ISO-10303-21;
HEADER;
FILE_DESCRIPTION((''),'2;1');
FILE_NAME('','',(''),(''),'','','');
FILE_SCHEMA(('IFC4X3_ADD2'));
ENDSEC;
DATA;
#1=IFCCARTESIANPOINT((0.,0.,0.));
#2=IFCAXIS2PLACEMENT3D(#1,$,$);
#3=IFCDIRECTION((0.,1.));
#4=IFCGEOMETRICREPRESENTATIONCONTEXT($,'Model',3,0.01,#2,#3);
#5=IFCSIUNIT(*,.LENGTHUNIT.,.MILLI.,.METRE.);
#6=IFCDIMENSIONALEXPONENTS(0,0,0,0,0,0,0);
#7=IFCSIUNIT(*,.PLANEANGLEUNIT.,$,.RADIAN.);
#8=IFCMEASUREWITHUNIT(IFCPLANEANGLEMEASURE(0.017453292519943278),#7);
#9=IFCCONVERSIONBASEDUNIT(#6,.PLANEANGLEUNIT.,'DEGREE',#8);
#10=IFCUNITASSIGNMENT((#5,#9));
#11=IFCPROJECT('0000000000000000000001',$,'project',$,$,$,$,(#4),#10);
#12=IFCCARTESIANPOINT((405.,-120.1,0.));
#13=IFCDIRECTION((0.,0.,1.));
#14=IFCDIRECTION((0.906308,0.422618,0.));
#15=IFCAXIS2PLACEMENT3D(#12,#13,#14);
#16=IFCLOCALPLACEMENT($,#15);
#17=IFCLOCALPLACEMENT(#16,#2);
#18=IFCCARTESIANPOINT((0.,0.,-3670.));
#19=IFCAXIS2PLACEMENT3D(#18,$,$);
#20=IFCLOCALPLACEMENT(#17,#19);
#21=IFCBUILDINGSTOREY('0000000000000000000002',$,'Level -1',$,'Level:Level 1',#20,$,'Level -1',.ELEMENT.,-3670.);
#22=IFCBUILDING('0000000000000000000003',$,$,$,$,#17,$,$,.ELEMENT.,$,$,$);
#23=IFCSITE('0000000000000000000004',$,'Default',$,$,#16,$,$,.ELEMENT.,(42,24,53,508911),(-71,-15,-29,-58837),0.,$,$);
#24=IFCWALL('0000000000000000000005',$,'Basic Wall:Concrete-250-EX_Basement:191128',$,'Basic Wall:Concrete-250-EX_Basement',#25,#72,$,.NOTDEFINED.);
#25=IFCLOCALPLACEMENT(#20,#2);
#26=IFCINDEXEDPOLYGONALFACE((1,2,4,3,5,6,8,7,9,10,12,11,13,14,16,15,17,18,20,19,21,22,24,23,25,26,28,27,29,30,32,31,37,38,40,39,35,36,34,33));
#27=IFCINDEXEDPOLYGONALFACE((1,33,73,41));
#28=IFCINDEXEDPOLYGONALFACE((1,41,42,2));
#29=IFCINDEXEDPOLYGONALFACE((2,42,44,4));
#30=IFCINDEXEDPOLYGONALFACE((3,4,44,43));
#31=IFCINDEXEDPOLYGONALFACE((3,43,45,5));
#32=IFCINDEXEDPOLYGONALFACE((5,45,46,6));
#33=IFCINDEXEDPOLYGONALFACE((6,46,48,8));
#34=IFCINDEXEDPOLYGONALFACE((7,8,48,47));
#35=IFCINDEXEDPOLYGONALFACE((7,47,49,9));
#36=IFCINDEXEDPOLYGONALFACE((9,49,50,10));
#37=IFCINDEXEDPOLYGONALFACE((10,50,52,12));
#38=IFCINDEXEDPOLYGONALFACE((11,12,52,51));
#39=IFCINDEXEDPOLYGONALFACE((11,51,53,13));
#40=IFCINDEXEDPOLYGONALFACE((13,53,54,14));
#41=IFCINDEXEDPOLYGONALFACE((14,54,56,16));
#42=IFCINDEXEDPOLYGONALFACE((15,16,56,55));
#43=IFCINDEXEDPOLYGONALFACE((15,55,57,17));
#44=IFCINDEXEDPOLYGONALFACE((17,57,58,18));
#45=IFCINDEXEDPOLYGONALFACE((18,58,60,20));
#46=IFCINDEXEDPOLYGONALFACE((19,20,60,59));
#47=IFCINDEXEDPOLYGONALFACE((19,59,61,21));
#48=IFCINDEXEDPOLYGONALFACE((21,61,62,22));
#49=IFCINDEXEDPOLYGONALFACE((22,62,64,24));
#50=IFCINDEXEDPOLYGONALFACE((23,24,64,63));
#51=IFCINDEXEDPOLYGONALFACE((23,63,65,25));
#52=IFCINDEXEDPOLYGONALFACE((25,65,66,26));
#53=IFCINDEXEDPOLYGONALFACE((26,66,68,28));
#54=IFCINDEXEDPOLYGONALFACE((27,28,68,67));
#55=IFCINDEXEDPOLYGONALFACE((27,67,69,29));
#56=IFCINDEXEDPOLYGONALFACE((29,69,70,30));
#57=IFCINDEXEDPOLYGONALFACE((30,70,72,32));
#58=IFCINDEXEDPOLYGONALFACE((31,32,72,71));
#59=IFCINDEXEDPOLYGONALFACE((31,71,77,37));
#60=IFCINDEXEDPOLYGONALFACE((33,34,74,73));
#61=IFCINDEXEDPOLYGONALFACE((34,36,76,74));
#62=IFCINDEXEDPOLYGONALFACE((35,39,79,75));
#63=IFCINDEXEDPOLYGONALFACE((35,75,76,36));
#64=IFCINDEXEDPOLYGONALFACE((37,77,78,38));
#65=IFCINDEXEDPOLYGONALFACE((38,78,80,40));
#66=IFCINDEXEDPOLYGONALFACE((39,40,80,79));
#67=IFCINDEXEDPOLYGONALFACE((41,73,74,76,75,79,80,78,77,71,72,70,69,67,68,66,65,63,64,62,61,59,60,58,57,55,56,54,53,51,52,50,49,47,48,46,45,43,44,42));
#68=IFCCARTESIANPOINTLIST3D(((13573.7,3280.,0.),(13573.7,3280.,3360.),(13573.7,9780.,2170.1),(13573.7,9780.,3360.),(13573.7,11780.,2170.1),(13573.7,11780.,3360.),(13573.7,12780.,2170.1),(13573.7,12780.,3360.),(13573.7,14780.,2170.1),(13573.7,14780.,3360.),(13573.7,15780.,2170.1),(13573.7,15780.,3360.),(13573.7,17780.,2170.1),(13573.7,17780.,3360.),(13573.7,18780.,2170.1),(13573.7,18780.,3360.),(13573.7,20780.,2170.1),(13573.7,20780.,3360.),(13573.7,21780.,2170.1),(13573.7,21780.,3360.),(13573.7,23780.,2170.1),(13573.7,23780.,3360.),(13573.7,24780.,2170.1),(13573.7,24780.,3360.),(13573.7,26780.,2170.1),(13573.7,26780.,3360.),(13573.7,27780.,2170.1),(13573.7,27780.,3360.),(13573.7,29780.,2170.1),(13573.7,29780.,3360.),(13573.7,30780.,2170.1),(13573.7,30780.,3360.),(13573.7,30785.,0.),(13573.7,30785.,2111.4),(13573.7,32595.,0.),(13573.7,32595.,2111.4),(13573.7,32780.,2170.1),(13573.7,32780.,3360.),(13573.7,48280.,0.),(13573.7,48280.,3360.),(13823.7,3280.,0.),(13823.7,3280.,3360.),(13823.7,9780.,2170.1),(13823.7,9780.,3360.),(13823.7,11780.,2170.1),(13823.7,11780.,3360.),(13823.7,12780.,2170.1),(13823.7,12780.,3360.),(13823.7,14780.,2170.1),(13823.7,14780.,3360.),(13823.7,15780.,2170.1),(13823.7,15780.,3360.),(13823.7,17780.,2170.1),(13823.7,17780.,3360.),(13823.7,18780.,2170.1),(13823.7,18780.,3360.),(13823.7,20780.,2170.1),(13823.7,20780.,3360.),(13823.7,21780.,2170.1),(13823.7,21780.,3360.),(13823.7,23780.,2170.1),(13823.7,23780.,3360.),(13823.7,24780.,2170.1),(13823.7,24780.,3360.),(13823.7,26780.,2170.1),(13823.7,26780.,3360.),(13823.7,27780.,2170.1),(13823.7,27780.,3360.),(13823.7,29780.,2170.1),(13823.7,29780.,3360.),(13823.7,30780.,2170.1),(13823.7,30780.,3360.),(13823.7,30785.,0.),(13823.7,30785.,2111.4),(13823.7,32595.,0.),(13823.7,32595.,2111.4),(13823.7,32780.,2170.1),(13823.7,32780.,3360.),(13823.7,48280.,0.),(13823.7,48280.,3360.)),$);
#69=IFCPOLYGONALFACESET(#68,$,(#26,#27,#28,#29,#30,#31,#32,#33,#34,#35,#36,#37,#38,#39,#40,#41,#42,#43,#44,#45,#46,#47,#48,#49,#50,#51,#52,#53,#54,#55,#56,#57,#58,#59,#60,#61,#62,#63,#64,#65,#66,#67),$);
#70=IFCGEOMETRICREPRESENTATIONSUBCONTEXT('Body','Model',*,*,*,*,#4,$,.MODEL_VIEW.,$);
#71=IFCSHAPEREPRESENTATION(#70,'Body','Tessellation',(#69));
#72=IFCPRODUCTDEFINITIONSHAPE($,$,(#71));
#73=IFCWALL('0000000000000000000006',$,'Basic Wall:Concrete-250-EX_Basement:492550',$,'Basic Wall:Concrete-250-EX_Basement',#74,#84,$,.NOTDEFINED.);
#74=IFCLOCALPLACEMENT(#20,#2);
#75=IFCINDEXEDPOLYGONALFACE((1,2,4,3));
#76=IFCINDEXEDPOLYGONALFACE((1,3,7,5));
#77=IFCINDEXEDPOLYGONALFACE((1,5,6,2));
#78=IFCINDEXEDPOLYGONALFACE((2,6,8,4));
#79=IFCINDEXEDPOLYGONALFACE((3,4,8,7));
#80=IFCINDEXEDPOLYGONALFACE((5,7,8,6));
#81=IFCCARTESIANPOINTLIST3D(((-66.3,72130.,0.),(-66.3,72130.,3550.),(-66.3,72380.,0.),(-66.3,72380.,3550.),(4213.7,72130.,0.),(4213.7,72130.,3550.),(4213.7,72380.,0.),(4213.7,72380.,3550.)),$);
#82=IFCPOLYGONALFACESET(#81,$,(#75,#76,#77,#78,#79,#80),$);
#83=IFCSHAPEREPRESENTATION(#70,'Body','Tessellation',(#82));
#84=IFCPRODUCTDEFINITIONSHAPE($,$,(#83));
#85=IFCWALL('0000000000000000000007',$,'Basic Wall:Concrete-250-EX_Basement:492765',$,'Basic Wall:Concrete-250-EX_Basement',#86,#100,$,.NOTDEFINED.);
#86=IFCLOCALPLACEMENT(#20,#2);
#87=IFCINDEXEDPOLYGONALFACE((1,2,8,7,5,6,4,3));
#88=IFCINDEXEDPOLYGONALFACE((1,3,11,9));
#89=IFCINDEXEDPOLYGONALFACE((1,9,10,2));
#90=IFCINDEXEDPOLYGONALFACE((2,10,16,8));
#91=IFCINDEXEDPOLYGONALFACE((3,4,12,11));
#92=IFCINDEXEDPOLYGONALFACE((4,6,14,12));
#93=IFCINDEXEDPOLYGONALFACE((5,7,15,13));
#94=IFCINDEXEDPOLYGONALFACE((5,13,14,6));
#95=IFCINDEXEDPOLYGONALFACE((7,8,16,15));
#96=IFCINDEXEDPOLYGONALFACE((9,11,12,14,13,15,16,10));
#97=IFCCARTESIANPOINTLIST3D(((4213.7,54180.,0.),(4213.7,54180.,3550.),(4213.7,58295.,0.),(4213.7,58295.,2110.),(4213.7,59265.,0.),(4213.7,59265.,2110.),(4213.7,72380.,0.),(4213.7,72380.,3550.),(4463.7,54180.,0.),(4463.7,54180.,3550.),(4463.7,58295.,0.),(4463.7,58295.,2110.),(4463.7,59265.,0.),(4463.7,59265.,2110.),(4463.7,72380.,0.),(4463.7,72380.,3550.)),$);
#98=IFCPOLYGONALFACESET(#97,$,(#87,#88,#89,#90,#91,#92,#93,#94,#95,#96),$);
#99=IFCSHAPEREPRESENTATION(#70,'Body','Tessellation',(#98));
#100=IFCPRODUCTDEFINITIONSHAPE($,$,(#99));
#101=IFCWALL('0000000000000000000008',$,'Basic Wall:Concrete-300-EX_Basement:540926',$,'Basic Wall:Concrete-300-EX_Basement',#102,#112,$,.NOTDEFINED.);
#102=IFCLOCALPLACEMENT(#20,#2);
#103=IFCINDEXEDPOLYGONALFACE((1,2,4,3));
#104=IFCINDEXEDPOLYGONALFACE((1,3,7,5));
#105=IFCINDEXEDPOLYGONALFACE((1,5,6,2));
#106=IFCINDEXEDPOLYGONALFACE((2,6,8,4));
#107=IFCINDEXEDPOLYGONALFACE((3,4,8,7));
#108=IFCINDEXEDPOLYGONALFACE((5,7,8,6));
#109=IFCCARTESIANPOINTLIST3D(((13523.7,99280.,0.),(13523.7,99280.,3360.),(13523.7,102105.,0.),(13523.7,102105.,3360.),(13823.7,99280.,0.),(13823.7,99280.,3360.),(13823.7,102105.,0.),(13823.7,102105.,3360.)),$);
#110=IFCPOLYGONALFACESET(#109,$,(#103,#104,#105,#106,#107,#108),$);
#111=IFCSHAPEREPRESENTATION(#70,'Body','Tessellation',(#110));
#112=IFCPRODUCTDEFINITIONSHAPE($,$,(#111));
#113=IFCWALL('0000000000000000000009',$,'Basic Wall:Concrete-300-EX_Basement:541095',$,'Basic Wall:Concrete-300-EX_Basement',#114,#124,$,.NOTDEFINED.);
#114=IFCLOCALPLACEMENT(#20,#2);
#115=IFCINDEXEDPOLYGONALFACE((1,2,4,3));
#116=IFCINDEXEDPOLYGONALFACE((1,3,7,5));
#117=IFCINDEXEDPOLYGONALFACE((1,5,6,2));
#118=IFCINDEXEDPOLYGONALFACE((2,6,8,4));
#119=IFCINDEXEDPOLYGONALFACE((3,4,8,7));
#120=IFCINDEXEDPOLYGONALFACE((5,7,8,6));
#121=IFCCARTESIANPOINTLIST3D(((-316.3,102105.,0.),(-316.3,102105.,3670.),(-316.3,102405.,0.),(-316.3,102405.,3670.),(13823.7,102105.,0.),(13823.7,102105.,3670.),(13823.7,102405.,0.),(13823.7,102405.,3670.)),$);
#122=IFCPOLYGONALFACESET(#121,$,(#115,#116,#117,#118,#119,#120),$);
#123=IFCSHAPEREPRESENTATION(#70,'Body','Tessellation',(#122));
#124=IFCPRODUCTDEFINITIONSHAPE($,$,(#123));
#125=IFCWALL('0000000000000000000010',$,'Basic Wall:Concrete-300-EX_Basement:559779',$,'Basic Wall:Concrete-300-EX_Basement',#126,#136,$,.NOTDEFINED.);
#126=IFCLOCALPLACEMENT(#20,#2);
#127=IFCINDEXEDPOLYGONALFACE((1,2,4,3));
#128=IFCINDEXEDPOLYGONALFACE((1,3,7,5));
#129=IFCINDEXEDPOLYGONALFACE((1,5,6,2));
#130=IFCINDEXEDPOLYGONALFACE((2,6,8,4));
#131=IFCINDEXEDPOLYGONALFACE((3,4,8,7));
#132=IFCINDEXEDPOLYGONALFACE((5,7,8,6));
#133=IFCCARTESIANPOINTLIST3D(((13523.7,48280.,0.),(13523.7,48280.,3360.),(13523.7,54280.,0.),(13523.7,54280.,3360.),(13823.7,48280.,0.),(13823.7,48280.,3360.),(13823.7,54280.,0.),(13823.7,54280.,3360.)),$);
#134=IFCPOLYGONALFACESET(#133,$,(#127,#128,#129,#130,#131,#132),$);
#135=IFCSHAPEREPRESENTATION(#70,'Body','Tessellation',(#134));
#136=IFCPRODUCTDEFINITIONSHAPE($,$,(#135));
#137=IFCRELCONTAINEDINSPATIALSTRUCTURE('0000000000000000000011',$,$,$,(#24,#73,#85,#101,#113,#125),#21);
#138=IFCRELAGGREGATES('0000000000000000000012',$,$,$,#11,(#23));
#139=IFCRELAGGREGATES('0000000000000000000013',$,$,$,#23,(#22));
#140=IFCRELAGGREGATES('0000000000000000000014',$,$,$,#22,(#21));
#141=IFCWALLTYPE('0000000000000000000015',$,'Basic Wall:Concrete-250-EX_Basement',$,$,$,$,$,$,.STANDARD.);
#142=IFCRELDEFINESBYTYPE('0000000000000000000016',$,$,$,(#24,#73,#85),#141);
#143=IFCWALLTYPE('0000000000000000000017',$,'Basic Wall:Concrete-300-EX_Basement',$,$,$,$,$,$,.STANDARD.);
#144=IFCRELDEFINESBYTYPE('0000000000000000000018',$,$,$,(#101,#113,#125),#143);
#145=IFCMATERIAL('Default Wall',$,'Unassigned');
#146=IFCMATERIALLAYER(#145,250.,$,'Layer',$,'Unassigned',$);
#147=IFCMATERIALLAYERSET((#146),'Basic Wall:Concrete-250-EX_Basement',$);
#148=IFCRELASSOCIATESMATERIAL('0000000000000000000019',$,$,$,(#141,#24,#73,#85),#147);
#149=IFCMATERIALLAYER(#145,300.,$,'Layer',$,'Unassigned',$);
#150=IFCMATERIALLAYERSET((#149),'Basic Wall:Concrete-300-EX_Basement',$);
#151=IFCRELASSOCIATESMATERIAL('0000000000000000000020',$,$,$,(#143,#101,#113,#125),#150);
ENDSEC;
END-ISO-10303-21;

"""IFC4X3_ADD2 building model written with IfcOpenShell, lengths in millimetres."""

from ifc_helpers import new_model, entity, si_unit, converted_unit, direction, frame, frame_2d, origin, place, context, subcontext, project, spatial, rectangle, extrude, material, layer, layer_set, type_object, element, save


model = new_model("IFC4X3_ADD2")

# Units and contexts
model_context = context("Model", 3, precision=0.01, world=origin(), true_north=direction((0.0, 1.0)))
body_context = subcontext(model_context, "Body", "Model", "MODEL_VIEW")
ifc_project = project(units=[si_unit("LENGTHUNIT", "METRE", prefix="MILLI"), converted_unit("PLANEANGLEUNIT", "DEGREE", entity("IfcPlaneAngleMeasure", 0.017453292519943278), si_unit("PLANEANGLEUNIT", "RADIAN"), dimensions=[0, 0, 0, 0, 0, 0, 0])], contexts=[model_context])

# Site, building, storey
site_placement = place(None, frame((405.0, -120.1, 0.0), z_axis=(0.0, 0.0, 1.0), x_axis=(0.906308, 0.422618, 0.0)))
site = spatial("IfcSite", under=ifc_project, at=site_placement, Name="Default", CompositionType="ELEMENT", RefLatitude=(42, 24, 53, 508911), RefLongitude=(-71, -15, -29, -58837), RefElevation=0.0)
building_placement = place(site_placement, origin())
building = spatial("IfcBuilding", under=site, at=building_placement, CompositionType="ELEMENT")
storey_placement = place(building_placement, frame((0.0, 0.0, -3670.0)))
storey = spatial("IfcBuildingStorey", under=building, at=storey_placement, Name="Level -1", ObjectType="Level:Level 1", LongName="Level -1", CompositionType="ELEMENT", Elevation=-3670.0)

# Shared definitions
ifc_material = material(Name="Default Wall", Category="Unassigned")

# Shared definitions
ifc_layer_1 = layer(ifc_material, 250.0, Name="Layer", Category="Unassigned")
ifc_layer_set_1 = layer_set([ifc_layer_1], Name="Basic Wall:Concrete-250-EX_Basement")
wall_type_1 = type_object("IfcWallType", Name="Basic Wall:Concrete-250-EX_Basement", PredefinedType="STANDARD", material=ifc_layer_set_1)

# Wall, openings
wall_1_placement = place(storey_placement, frame((13698.7, 48280.0, 0.0), z_axis=(0.0, 0.0, 1.0), x_axis=(0.0, -1.0, 0.0)))
wall_1 = element("IfcWall", 1, at=wall_1_placement, inside=storey, type_object=wall_type_1, material=ifc_layer_set_1, Name="Basic Wall:Concrete-250-EX_Basement:191128", ObjectType="Basic Wall:Concrete-250-EX_Basement", PredefinedType="NOTDEFINED", context=body_context, shape_type="SweptSolid", body=[
    extrude(rectangle(XDim=45000.0, YDim=250.0, at=frame_2d((22500.0, 0.0), x_axis=(-1.0, 0.0))), origin(), (0.0, 0.0, 1.0), 3360.0),
])
opening_1_placement = place(wall_1_placement, frame((17495.0, -125.0, 0.0)))
element("IfcOpeningElement", 2, at=opening_1_placement, cuts=wall_1, PredefinedType="OPENING", context=body_context, shape_type="SweptSolid", body=[
    extrude(rectangle(XDim=2111.4, YDim=1810.0, at=frame_2d((0.0, 0.0), x_axis=(1.0, 0.0))), frame((-905.0, 0.0, 1055.7), z_axis=(0.0, 1.0, 0.0), x_axis=(0.0, 0.0, -1.0)), (0.0, 0.0, 1.0), 250.0),
])
opening_2_placement = place(wall_1_placement, origin())
element("IfcOpeningElement", 3, at=opening_2_placement, cuts=wall_1, PredefinedType="OPENING", context=body_context, shape_type="SweptSolid", body=[
    extrude(rectangle(XDim=1189.9, YDim=2000.0, at=frame_2d((0.0, 0.0), x_axis=(0.0, 1.0))), frame((37500.0, 125.0, 2765.1), z_axis=(0.0, -1.0, 0.0), x_axis=(-1.0, 0.0, 0.0)), (0.0, 0.0, 1.0), 250.0),
])
opening_3_placement = place(wall_1_placement, origin())
element("IfcOpeningElement", 4, at=opening_3_placement, cuts=wall_1, PredefinedType="OPENING", context=body_context, shape_type="SweptSolid", body=[
    extrude(rectangle(XDim=1189.9, YDim=2000.0, at=frame_2d((0.0, 0.0), x_axis=(0.0, 1.0))), frame((34500.0, 125.0, 2765.1), z_axis=(0.0, -1.0, 0.0), x_axis=(-1.0, 0.0, 0.0)), (0.0, 0.0, 1.0), 250.0),
])
opening_4_placement = place(wall_1_placement, origin())
element("IfcOpeningElement", 5, at=opening_4_placement, cuts=wall_1, PredefinedType="OPENING", context=body_context, shape_type="SweptSolid", body=[
    extrude(rectangle(XDim=1189.9, YDim=2000.0, at=frame_2d((0.0, 0.0), x_axis=(0.0, 1.0))), frame((31500.0, 125.0, 2765.1), z_axis=(0.0, -1.0, 0.0), x_axis=(-1.0, 0.0, 0.0)), (0.0, 0.0, 1.0), 250.0),
])
opening_5_placement = place(wall_1_placement, origin())
element("IfcOpeningElement", 6, at=opening_5_placement, cuts=wall_1, PredefinedType="OPENING", context=body_context, shape_type="SweptSolid", body=[
    extrude(rectangle(XDim=1189.9, YDim=2000.0, at=frame_2d((0.0, 0.0), x_axis=(0.0, 1.0))), frame((28500.0, 125.0, 2765.1), z_axis=(0.0, -1.0, 0.0), x_axis=(-1.0, 0.0, 0.0)), (0.0, 0.0, 1.0), 250.0),
])
opening_6_placement = place(wall_1_placement, origin())
element("IfcOpeningElement", 7, at=opening_6_placement, cuts=wall_1, PredefinedType="OPENING", context=body_context, shape_type="SweptSolid", body=[
    extrude(rectangle(XDim=1189.9, YDim=2000.0, at=frame_2d((0.0, 0.0), x_axis=(0.0, 1.0))), frame((25500.0, 125.0, 2765.1), z_axis=(0.0, -1.0, 0.0), x_axis=(-1.0, 0.0, 0.0)), (0.0, 0.0, 1.0), 250.0),
])
opening_7_placement = place(wall_1_placement, origin())
element("IfcOpeningElement", 8, at=opening_7_placement, cuts=wall_1, PredefinedType="OPENING", context=body_context, shape_type="SweptSolid", body=[
    extrude(rectangle(XDim=1189.9, YDim=2000.0, at=frame_2d((0.0, 0.0), x_axis=(0.0, 1.0))), frame((22500.0, 125.0, 2765.1), z_axis=(0.0, -1.0, 0.0), x_axis=(-1.0, 0.0, 0.0)), (0.0, 0.0, 1.0), 250.0),
])
opening_8_placement = place(wall_1_placement, origin())
element("IfcOpeningElement", 9, at=opening_8_placement, cuts=wall_1, PredefinedType="OPENING", context=body_context, shape_type="SweptSolid", body=[
    extrude(rectangle(XDim=1189.9, YDim=2000.0, at=frame_2d((0.0, 0.0), x_axis=(0.0, 1.0))), frame((19500.0, 125.0, 2765.1), z_axis=(0.0, -1.0, 0.0), x_axis=(-1.0, 0.0, 0.0)), (0.0, 0.0, 1.0), 250.0),
])
opening_9_placement = place(wall_1_placement, origin())
element("IfcOpeningElement", 10, at=opening_9_placement, cuts=wall_1, PredefinedType="OPENING", context=body_context, shape_type="SweptSolid", body=[
    extrude(rectangle(XDim=1189.9, YDim=2000.0, at=frame_2d((0.0, 0.0), x_axis=(0.0, 1.0))), frame((16500.0, 125.0, 2765.1), z_axis=(0.0, -1.0, 0.0), x_axis=(-1.0, 0.0, 0.0)), (0.0, 0.0, 1.0), 250.0),
])

# Wall
wall_2_placement = place(storey_placement, frame((-66.3, 72255.0, 0.0)))
element("IfcWall", 11, at=wall_2_placement, inside=storey, type_object=wall_type_1, material=ifc_layer_set_1, Name="Basic Wall:Concrete-250-EX_Basement:492550", ObjectType="Basic Wall:Concrete-250-EX_Basement", PredefinedType="NOTDEFINED", context=body_context, shape_type="SweptSolid", body=[
    extrude(rectangle(XDim=4280.0, YDim=250.0, at=frame_2d((2140.0, 0.0), x_axis=(-1.0, 0.0))), origin(), (0.0, 0.0, 1.0), 3550.0),
])

# Wall, opening
wall_3_placement = place(storey_placement, frame((4338.7, 54180.0, 0.0), z_axis=(0.0, 0.0, 1.0), x_axis=(0.0, 1.0, 0.0)))
wall_3 = element("IfcWall", 12, at=wall_3_placement, inside=storey, type_object=wall_type_1, material=ifc_layer_set_1, Name="Basic Wall:Concrete-250-EX_Basement:492765", ObjectType="Basic Wall:Concrete-250-EX_Basement", PredefinedType="NOTDEFINED", context=body_context, shape_type="SweptSolid", body=[
    extrude(rectangle(XDim=18200.0, YDim=250.0, at=frame_2d((9100.0, 0.0), x_axis=(-1.0, 0.0))), origin(), (0.0, 0.0, 1.0), 3550.0),
])
opening_10_placement = place(wall_3_placement, frame((4115.0, -125.0, 0.0)))
element("IfcOpeningElement", 13, at=opening_10_placement, cuts=wall_3, PredefinedType="OPENING", context=body_context, shape_type="SweptSolid", body=[
    extrude(rectangle(XDim=2110.0, YDim=970.0, at=frame_2d((1055.0, 485.0), x_axis=(1.0, 0.0))), frame((0.0, 0.0, 0.0), z_axis=(0.0, 1.0, 0.0), x_axis=(0.0, 0.0, 1.0)), (0.0, 0.0, 1.0), 250.0),
])

# Walls
ifc_layer_2 = layer(ifc_material, 300.0, Name="Layer", Category="Unassigned")
ifc_layer_set_2 = layer_set([ifc_layer_2], Name="Basic Wall:Concrete-300-EX_Basement")
wall_type_2 = type_object("IfcWallType", Name="Basic Wall:Concrete-300-EX_Basement", PredefinedType="STANDARD", material=ifc_layer_set_2)
wall_4_placement = place(storey_placement, frame((13673.7, 102105.0, 0.0), z_axis=(0.0, 0.0, 1.0), x_axis=(0.0, -1.0, 0.0)))
element("IfcWall", 14, at=wall_4_placement, inside=storey, type_object=wall_type_2, material=ifc_layer_set_2, Name="Basic Wall:Concrete-300-EX_Basement:540926", ObjectType="Basic Wall:Concrete-300-EX_Basement", PredefinedType="NOTDEFINED", context=body_context, shape_type="SweptSolid", body=[
    extrude(rectangle(XDim=2825.0, YDim=300.0, at=frame_2d((1412.5, 0.0), x_axis=(-1.0, 0.0))), origin(), (0.0, 0.0, 1.0), 3360.0),
])
wall_5_placement = place(storey_placement, frame((-316.3, 102255.0, 0.0)))
element("IfcWall", 15, at=wall_5_placement, inside=storey, type_object=wall_type_2, material=ifc_layer_set_2, Name="Basic Wall:Concrete-300-EX_Basement:541095", ObjectType="Basic Wall:Concrete-300-EX_Basement", PredefinedType="NOTDEFINED", context=body_context, shape_type="SweptSolid", body=[
    extrude(rectangle(XDim=14140.0, YDim=300.0, at=frame_2d((7070.0, 0.0), x_axis=(-1.0, 0.0))), origin(), (0.0, 0.0, 1.0), 3670.0),
])
wall_6_placement = place(storey_placement, frame((13673.7, 54280.0, 0.0), z_axis=(0.0, 0.0, 1.0), x_axis=(0.0, -1.0, 0.0)))
element("IfcWall", 16, at=wall_6_placement, inside=storey, type_object=wall_type_2, material=ifc_layer_set_2, Name="Basic Wall:Concrete-300-EX_Basement:559779", ObjectType="Basic Wall:Concrete-300-EX_Basement", PredefinedType="NOTDEFINED", context=body_context, shape_type="SweptSolid", body=[
    extrude(rectangle(XDim=6000.0, YDim=300.0, at=frame_2d((3000.0, 0.0), x_axis=(-1.0, 0.0))), origin(), (0.0, 0.0, 1.0), 3360.0),
])

save(model, "model.ifc")
